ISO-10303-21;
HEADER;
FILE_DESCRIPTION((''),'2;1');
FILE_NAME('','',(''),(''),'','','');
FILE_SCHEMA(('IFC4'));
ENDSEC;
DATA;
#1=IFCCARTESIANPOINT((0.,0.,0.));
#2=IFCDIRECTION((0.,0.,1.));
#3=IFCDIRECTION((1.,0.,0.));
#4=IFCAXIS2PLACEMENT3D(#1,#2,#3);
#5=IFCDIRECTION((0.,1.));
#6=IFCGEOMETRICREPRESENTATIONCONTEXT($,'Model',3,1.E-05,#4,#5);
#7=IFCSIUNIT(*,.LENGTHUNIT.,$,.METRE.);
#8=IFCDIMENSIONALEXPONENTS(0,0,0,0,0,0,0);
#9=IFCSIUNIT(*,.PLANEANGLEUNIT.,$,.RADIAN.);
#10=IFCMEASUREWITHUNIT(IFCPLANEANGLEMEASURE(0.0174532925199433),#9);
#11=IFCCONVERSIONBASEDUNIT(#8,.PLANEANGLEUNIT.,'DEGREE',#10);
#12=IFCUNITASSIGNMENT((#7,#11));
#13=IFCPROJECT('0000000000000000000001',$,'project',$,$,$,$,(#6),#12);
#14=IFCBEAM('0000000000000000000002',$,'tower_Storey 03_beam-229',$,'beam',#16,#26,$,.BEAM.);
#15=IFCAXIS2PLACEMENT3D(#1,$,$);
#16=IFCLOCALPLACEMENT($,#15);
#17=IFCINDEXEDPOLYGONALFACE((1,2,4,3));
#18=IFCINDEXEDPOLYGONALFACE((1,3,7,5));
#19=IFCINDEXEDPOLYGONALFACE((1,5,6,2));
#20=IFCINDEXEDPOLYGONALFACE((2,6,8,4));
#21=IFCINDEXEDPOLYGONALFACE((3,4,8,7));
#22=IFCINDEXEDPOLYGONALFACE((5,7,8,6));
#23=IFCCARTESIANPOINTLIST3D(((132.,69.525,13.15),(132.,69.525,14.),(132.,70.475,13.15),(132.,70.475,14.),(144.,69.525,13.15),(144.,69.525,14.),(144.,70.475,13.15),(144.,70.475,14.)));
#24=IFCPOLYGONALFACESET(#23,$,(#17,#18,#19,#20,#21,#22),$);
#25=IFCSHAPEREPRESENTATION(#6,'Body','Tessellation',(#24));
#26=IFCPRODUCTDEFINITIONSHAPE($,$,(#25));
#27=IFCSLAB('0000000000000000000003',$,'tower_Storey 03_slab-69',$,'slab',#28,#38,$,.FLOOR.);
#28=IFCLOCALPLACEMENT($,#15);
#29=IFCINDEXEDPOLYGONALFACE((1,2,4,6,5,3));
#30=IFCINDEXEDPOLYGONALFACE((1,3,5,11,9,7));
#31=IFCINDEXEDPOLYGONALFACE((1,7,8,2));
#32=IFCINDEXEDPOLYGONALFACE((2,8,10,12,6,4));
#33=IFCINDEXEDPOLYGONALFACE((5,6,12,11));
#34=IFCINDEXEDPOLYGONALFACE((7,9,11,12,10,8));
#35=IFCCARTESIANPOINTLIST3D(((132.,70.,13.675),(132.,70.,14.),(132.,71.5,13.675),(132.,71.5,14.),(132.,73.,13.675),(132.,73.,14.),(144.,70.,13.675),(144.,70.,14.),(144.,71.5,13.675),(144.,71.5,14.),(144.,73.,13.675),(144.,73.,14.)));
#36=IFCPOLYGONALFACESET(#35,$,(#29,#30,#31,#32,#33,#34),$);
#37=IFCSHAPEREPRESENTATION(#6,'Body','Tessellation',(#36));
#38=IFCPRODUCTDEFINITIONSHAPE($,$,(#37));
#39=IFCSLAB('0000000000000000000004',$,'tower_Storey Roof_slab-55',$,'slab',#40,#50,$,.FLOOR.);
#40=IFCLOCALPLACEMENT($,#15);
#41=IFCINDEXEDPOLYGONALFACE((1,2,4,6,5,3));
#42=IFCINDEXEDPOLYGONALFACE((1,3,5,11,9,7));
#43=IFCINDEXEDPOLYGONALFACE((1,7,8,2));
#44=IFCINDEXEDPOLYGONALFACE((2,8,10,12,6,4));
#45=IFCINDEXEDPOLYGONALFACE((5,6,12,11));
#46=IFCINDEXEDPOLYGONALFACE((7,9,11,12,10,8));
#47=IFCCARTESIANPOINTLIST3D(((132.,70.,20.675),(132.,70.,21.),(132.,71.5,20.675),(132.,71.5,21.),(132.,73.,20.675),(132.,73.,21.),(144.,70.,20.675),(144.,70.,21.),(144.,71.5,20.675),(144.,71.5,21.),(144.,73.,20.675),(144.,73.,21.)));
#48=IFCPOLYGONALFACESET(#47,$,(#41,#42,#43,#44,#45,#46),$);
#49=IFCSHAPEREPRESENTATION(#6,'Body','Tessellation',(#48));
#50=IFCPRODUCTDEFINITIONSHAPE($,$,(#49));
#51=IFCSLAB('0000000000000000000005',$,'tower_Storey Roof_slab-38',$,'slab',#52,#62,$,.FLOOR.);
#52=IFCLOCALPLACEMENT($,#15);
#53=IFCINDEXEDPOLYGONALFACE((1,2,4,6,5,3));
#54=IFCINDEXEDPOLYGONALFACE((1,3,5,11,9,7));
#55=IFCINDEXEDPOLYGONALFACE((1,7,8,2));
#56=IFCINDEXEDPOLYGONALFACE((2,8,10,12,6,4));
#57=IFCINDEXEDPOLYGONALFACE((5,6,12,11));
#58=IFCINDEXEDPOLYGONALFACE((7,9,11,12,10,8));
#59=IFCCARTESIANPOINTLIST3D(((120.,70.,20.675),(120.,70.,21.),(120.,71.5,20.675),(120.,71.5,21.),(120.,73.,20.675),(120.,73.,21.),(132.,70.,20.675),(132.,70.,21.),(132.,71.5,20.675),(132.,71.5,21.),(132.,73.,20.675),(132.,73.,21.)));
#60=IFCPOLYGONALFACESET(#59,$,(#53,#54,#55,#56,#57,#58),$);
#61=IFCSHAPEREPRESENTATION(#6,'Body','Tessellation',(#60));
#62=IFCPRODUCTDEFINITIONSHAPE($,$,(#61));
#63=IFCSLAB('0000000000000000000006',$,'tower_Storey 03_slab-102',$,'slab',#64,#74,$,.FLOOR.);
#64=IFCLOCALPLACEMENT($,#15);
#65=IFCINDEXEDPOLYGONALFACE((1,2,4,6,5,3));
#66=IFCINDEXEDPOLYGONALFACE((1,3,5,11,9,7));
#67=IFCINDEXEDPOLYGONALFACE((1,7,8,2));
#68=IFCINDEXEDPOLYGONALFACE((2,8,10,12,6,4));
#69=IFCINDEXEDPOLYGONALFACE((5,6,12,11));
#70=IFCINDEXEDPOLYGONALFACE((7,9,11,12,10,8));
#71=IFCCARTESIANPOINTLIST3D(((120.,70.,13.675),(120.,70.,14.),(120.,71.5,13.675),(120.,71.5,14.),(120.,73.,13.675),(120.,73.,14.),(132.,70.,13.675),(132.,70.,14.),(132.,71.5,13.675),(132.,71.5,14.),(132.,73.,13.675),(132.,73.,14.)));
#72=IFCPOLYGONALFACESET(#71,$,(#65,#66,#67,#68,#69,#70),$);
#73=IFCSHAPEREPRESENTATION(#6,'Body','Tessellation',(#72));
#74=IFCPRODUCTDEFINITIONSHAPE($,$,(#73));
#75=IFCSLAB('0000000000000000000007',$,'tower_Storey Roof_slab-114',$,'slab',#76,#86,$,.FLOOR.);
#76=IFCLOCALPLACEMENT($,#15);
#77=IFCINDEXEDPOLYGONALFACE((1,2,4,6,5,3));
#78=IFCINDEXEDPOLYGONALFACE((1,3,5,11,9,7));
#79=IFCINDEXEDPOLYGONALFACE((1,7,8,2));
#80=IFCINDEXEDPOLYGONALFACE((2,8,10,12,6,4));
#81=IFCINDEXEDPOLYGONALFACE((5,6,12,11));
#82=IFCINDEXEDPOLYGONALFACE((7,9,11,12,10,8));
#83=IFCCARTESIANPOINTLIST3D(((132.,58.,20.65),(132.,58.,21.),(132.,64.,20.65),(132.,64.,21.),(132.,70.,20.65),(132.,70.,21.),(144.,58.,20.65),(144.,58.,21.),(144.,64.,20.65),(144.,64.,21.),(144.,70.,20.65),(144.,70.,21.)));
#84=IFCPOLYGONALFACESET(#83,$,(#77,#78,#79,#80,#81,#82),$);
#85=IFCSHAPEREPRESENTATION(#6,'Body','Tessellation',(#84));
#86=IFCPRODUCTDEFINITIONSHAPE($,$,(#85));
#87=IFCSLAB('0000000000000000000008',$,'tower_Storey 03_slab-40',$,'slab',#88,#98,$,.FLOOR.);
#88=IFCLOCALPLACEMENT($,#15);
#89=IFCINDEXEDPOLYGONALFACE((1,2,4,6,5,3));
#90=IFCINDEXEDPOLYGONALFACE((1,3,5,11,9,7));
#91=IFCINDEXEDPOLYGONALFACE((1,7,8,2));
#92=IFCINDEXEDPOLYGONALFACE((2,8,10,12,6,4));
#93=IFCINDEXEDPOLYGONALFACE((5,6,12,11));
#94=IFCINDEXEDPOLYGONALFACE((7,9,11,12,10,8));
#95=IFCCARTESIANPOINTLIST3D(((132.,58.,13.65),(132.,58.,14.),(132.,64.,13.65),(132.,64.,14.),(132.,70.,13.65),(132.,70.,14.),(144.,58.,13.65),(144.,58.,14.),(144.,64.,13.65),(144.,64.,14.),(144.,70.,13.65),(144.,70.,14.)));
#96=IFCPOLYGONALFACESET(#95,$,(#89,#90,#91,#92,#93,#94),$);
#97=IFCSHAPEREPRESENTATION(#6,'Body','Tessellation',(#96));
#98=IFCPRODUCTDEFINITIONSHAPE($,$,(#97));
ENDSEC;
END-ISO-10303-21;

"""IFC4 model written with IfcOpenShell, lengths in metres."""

from ifc_helpers import new_model, entity, si_unit, converted_unit, direction, frame, origin_with_axes, place, context, project, polyline, outline, extrude, element, save


model = new_model("IFC4")

# Units and contexts
model_context = context("Model", 3, precision=1e-05, world=origin_with_axes(), true_north=direction((0.0, 1.0)))
ifc_project = project(units=[si_unit("LENGTHUNIT", "METRE"), converted_unit("PLANEANGLEUNIT", "DEGREE", entity("IfcPlaneAngleMeasure", 0.0174532925199433), si_unit("PLANEANGLEUNIT", "RADIAN"), dimensions=[0, 0, 0, 0, 0, 0, 0])], contexts=[model_context])

# Shared definitions
placement_1 = place(None, origin_with_axes())
placement_2 = place(placement_1, frame((0.0, 0.0, 14.0), z_axis=(0.0, 0.0, 1.0), x_axis=(1.0, 0.0, 0.0)))

# Beam
placement_3 = place(placement_1, frame((0.0, 0.0, 21.0), z_axis=(0.0, 0.0, 1.0), x_axis=(1.0, 0.0, 0.0)))
beam_1_placement = place(placement_2, frame((132.0, 70.0, -0.425), z_axis=(1.0, 0.0, 0.0), x_axis=(0.0, 1.0, 0.0)))
element("IfcBeam", 1, at=beam_1_placement, Name="tower_Storey 03_beam-229", ObjectType="beam", PredefinedType="BEAM", context=model_context, body=[
    extrude(outline(polyline([(0.475, 0.425, 0.0), (-0.475, 0.425, 0.0), (-0.475, -0.425, 0.0), (0.475, -0.425, 0.0), (0.475, 0.425, 0.0)])), origin_with_axes(), (0.0, 0.0, 1.0), 12.0),
])

# Slabs
slab_1_placement = place(placement_2, frame((138.0, 71.5, -0.325), z_axis=(0.0, 0.0, 1.0), x_axis=(1.0, 0.0, 0.0)))
element("IfcSlab", 2, at=slab_1_placement, Name="tower_Storey 03_slab-69", ObjectType="slab", PredefinedType="FLOOR", context=model_context, body=[
    extrude(outline(polyline([(-6.0, -1.5, 0.0), (6.0, -1.5, 0.0), (6.0, 0.0, 0.0), (6.0, 1.5, 0.0), (-6.0, 1.5, 0.0), (-6.0, 0.0, 0.0), (-6.0, -1.5, 0.0)])), origin_with_axes(), (0.0, 0.0, 1.0), 0.325),
])
for number, where, z_axis, x_axis, name in (
    (3, (138.0, 71.5, -0.325), (0.0, 0.0, 1.0), (1.0, 0.0, 0.0), "tower_Storey Roof_slab-55"),
    (4, (126.0, 71.5, -0.325), (0.0, 0.0, 1.0), (1.0, 0.0, 0.0), "tower_Storey Roof_slab-38"),
):
    element("IfcSlab", number, at=place(placement_3, frame(where, z_axis=z_axis, x_axis=x_axis)), Name=name, ObjectType="slab", PredefinedType="FLOOR", context=model_context, body=[
        extrude(outline(polyline([(-6.0, -1.5, 0.0), (6.0, -1.5, 0.0), (6.0, 0.0, 0.0), (6.0, 1.5, 0.0), (-6.0, 1.5, 0.0), (-6.0, 0.0, 0.0), (-6.0, -1.5, 0.0)])), origin_with_axes(), (0.0, 0.0, 1.0), 0.325),
    ])
slab_2_placement = place(placement_2, frame((126.0, 71.5, -0.325), z_axis=(0.0, 0.0, 1.0), x_axis=(1.0, 0.0, 0.0)))
element("IfcSlab", 5, at=slab_2_placement, Name="tower_Storey 03_slab-102", ObjectType="slab", PredefinedType="FLOOR", context=model_context, body=[
    extrude(outline(polyline([(-6.0, -1.5, 0.0), (6.0, -1.5, 0.0), (6.0, 0.0, 0.0), (6.0, 1.5, 0.0), (-6.0, 1.5, 0.0), (-6.0, 0.0, 0.0), (-6.0, -1.5, 0.0)])), origin_with_axes(), (0.0, 0.0, 1.0), 0.325),
])
slab_3_placement = place(placement_3, frame((138.0, 64.0, -0.35), z_axis=(0.0, 0.0, 1.0), x_axis=(1.0, 0.0, 0.0)))
element("IfcSlab", 6, at=slab_3_placement, Name="tower_Storey Roof_slab-114", ObjectType="slab", PredefinedType="FLOOR", context=model_context, body=[
    extrude(outline(polyline([(-6.0, -6.0, 0.0), (6.0, -6.0, 0.0), (6.0, 0.0, 0.0), (6.0, 6.0, 0.0), (-6.0, 6.0, 0.0), (-6.0, 0.0, 0.0), (-6.0, -6.0, 0.0)])), origin_with_axes(), (0.0, 0.0, 1.0), 0.35),
])
slab_4_placement = place(placement_2, frame((138.0, 64.0, -0.35), z_axis=(0.0, 0.0, 1.0), x_axis=(1.0, 0.0, 0.0)))
element("IfcSlab", 7, at=slab_4_placement, Name="tower_Storey 03_slab-40", ObjectType="slab", PredefinedType="FLOOR", context=model_context, body=[
    extrude(outline(polyline([(-6.0, -6.0, 0.0), (6.0, -6.0, 0.0), (6.0, 0.0, 0.0), (6.0, 6.0, 0.0), (-6.0, 6.0, 0.0), (-6.0, 0.0, 0.0), (-6.0, -6.0, 0.0)])), origin_with_axes(), (0.0, 0.0, 1.0), 0.35),
])

save(model, "model.ifc")
